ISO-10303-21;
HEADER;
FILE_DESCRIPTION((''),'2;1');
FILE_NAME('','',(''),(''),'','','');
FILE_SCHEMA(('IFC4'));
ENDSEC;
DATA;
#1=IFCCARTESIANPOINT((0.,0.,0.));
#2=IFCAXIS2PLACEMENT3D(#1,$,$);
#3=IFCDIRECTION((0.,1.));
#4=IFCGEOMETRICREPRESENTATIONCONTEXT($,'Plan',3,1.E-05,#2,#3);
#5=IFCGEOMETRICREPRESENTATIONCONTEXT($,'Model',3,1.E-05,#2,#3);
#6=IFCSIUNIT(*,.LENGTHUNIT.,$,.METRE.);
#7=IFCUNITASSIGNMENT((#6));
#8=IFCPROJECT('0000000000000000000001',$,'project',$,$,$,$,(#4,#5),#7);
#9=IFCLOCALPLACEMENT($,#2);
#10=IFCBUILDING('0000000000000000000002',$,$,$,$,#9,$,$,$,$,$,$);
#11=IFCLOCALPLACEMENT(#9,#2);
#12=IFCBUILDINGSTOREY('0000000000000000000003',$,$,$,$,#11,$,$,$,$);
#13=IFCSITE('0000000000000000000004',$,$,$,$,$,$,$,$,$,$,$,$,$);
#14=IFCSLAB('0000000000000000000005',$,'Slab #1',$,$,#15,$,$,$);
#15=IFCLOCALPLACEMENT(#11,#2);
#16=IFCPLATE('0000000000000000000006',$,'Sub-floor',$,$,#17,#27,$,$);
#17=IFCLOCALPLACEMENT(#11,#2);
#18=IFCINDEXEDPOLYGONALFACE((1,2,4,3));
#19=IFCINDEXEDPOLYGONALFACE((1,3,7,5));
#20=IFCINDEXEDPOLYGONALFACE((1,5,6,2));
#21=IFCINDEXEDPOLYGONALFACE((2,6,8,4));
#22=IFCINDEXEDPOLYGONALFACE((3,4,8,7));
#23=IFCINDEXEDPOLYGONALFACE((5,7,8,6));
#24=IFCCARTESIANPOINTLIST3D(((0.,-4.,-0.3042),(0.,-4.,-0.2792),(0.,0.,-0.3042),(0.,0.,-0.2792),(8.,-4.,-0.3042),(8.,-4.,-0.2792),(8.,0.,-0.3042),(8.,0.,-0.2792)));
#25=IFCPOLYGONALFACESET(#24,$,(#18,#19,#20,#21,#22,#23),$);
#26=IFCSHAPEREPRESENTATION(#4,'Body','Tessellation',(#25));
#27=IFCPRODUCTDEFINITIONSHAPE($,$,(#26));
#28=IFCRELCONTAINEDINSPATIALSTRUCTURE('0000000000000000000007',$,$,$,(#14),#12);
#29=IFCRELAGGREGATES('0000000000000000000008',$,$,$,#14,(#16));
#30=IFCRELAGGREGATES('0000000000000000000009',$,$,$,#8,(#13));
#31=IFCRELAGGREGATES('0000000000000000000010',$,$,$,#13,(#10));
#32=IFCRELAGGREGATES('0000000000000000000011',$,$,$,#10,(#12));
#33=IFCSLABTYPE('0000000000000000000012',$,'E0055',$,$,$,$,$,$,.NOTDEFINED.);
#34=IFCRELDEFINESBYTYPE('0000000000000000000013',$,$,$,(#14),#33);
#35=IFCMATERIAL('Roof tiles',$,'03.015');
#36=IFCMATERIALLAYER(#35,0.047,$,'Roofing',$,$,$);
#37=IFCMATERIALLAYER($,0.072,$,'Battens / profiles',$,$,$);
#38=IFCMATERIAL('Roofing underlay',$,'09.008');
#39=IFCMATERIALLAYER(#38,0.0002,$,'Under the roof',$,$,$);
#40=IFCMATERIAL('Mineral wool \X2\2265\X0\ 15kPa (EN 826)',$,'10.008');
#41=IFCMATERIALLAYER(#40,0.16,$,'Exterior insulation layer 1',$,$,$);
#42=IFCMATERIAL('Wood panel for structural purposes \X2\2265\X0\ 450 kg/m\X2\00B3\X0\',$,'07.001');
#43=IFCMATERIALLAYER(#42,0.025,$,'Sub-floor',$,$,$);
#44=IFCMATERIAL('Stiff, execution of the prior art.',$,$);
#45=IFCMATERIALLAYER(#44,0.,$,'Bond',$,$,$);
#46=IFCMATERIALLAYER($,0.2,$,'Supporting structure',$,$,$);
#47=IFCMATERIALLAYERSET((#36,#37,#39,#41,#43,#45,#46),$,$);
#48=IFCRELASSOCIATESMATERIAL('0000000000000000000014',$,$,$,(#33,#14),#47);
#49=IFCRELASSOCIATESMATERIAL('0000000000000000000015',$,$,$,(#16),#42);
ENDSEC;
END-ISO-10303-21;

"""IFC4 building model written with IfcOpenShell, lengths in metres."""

from ifc_helpers import new_model, si_unit, direction, frame, frame_2d, origin, place, context, project, spatial, rectangle, extrude, material, layer, layer_set, type_object, element, aggregate, save


model = new_model("IFC4")

# Units and contexts
plan_context = context("Plan", 3, precision=1e-05, world=origin(), true_north=direction((0.0, 1.0)))
model_context = context("Model", 3, precision=1e-05, world=origin(), true_north=direction((0.0, 1.0)))
ifc_project = project(units=[si_unit("LENGTHUNIT", "METRE")], contexts=[plan_context, model_context])

# Site, building, storey
site = spatial("IfcSite", under=ifc_project)
building_placement = place(None, origin())
building = spatial("IfcBuilding", under=site, at=building_placement)
storey_placement = place(building_placement, origin())
storey = spatial("IfcBuildingStorey", under=building, at=storey_placement)

# Slab, plate
ifc_material_1 = material(Name="Roof tiles", Category="03.015")
ifc_layer_1 = layer(ifc_material_1, 0.047, Name="Roofing")
ifc_layer_2 = layer(None, 0.072, Name="Battens / profiles")
ifc_material_2 = material(Name="Roofing underlay", Category="09.008")
ifc_layer_3 = layer(ifc_material_2, 0.0002, Name="Under the roof")
ifc_material_3 = material(Name="Mineral wool ≥ 15kPa (EN 826)", Category="10.008")
ifc_layer_4 = layer(ifc_material_3, 0.16, Name="Exterior insulation layer 1")
ifc_material_4 = material(Name="Wood panel for structural purposes ≥ 450 kg/m³", Category="07.001")
ifc_layer_5 = layer(ifc_material_4, 0.025, Name="Sub-floor")
ifc_material_5 = material(Name="Stiff, execution of the prior art.")
ifc_layer_6 = layer(ifc_material_5, 0.0, Name="Bond")
ifc_layer_7 = layer(None, 0.2, Name="Supporting structure")
ifc_layer_set = layer_set([ifc_layer_1, ifc_layer_2, ifc_layer_3, ifc_layer_4, ifc_layer_5, ifc_layer_6, ifc_layer_7])
slab_type = type_object("IfcSlabType", Name="E0055", PredefinedType="NOTDEFINED", material=ifc_layer_set)
slab_placement = place(None, frame((0.0, 0.0, 0.0), z_axis=(0.0, 0.0, -1.0), x_axis=(1.0, 0.0, 0.0)))
slab = element("IfcSlab", 1, at=slab_placement, inside=storey, type_object=slab_type, material=ifc_layer_set, Name="Slab #1")
plate_1_placement = place(slab_placement, origin())
plate_1 = element("IfcPlate", 2, at=plate_1_placement, material=ifc_material_4, Name="Sub-floor", context=plan_context, shape_type="SweptSolid", body=[
    extrude(rectangle(XDim=8.0, YDim=4.0, at=frame_2d((4.0, 2.0), x_axis=(1.0, 0.0))), frame((0.0, 0.0, 0.2792), z_axis=(0.0, 0.0, 1.0), x_axis=(1.0, 0.0, 0.0)), (0.0, 0.0, 1.0), 0.025),
])
aggregate(slab, [plate_1])

save(model, "model.ifc")
